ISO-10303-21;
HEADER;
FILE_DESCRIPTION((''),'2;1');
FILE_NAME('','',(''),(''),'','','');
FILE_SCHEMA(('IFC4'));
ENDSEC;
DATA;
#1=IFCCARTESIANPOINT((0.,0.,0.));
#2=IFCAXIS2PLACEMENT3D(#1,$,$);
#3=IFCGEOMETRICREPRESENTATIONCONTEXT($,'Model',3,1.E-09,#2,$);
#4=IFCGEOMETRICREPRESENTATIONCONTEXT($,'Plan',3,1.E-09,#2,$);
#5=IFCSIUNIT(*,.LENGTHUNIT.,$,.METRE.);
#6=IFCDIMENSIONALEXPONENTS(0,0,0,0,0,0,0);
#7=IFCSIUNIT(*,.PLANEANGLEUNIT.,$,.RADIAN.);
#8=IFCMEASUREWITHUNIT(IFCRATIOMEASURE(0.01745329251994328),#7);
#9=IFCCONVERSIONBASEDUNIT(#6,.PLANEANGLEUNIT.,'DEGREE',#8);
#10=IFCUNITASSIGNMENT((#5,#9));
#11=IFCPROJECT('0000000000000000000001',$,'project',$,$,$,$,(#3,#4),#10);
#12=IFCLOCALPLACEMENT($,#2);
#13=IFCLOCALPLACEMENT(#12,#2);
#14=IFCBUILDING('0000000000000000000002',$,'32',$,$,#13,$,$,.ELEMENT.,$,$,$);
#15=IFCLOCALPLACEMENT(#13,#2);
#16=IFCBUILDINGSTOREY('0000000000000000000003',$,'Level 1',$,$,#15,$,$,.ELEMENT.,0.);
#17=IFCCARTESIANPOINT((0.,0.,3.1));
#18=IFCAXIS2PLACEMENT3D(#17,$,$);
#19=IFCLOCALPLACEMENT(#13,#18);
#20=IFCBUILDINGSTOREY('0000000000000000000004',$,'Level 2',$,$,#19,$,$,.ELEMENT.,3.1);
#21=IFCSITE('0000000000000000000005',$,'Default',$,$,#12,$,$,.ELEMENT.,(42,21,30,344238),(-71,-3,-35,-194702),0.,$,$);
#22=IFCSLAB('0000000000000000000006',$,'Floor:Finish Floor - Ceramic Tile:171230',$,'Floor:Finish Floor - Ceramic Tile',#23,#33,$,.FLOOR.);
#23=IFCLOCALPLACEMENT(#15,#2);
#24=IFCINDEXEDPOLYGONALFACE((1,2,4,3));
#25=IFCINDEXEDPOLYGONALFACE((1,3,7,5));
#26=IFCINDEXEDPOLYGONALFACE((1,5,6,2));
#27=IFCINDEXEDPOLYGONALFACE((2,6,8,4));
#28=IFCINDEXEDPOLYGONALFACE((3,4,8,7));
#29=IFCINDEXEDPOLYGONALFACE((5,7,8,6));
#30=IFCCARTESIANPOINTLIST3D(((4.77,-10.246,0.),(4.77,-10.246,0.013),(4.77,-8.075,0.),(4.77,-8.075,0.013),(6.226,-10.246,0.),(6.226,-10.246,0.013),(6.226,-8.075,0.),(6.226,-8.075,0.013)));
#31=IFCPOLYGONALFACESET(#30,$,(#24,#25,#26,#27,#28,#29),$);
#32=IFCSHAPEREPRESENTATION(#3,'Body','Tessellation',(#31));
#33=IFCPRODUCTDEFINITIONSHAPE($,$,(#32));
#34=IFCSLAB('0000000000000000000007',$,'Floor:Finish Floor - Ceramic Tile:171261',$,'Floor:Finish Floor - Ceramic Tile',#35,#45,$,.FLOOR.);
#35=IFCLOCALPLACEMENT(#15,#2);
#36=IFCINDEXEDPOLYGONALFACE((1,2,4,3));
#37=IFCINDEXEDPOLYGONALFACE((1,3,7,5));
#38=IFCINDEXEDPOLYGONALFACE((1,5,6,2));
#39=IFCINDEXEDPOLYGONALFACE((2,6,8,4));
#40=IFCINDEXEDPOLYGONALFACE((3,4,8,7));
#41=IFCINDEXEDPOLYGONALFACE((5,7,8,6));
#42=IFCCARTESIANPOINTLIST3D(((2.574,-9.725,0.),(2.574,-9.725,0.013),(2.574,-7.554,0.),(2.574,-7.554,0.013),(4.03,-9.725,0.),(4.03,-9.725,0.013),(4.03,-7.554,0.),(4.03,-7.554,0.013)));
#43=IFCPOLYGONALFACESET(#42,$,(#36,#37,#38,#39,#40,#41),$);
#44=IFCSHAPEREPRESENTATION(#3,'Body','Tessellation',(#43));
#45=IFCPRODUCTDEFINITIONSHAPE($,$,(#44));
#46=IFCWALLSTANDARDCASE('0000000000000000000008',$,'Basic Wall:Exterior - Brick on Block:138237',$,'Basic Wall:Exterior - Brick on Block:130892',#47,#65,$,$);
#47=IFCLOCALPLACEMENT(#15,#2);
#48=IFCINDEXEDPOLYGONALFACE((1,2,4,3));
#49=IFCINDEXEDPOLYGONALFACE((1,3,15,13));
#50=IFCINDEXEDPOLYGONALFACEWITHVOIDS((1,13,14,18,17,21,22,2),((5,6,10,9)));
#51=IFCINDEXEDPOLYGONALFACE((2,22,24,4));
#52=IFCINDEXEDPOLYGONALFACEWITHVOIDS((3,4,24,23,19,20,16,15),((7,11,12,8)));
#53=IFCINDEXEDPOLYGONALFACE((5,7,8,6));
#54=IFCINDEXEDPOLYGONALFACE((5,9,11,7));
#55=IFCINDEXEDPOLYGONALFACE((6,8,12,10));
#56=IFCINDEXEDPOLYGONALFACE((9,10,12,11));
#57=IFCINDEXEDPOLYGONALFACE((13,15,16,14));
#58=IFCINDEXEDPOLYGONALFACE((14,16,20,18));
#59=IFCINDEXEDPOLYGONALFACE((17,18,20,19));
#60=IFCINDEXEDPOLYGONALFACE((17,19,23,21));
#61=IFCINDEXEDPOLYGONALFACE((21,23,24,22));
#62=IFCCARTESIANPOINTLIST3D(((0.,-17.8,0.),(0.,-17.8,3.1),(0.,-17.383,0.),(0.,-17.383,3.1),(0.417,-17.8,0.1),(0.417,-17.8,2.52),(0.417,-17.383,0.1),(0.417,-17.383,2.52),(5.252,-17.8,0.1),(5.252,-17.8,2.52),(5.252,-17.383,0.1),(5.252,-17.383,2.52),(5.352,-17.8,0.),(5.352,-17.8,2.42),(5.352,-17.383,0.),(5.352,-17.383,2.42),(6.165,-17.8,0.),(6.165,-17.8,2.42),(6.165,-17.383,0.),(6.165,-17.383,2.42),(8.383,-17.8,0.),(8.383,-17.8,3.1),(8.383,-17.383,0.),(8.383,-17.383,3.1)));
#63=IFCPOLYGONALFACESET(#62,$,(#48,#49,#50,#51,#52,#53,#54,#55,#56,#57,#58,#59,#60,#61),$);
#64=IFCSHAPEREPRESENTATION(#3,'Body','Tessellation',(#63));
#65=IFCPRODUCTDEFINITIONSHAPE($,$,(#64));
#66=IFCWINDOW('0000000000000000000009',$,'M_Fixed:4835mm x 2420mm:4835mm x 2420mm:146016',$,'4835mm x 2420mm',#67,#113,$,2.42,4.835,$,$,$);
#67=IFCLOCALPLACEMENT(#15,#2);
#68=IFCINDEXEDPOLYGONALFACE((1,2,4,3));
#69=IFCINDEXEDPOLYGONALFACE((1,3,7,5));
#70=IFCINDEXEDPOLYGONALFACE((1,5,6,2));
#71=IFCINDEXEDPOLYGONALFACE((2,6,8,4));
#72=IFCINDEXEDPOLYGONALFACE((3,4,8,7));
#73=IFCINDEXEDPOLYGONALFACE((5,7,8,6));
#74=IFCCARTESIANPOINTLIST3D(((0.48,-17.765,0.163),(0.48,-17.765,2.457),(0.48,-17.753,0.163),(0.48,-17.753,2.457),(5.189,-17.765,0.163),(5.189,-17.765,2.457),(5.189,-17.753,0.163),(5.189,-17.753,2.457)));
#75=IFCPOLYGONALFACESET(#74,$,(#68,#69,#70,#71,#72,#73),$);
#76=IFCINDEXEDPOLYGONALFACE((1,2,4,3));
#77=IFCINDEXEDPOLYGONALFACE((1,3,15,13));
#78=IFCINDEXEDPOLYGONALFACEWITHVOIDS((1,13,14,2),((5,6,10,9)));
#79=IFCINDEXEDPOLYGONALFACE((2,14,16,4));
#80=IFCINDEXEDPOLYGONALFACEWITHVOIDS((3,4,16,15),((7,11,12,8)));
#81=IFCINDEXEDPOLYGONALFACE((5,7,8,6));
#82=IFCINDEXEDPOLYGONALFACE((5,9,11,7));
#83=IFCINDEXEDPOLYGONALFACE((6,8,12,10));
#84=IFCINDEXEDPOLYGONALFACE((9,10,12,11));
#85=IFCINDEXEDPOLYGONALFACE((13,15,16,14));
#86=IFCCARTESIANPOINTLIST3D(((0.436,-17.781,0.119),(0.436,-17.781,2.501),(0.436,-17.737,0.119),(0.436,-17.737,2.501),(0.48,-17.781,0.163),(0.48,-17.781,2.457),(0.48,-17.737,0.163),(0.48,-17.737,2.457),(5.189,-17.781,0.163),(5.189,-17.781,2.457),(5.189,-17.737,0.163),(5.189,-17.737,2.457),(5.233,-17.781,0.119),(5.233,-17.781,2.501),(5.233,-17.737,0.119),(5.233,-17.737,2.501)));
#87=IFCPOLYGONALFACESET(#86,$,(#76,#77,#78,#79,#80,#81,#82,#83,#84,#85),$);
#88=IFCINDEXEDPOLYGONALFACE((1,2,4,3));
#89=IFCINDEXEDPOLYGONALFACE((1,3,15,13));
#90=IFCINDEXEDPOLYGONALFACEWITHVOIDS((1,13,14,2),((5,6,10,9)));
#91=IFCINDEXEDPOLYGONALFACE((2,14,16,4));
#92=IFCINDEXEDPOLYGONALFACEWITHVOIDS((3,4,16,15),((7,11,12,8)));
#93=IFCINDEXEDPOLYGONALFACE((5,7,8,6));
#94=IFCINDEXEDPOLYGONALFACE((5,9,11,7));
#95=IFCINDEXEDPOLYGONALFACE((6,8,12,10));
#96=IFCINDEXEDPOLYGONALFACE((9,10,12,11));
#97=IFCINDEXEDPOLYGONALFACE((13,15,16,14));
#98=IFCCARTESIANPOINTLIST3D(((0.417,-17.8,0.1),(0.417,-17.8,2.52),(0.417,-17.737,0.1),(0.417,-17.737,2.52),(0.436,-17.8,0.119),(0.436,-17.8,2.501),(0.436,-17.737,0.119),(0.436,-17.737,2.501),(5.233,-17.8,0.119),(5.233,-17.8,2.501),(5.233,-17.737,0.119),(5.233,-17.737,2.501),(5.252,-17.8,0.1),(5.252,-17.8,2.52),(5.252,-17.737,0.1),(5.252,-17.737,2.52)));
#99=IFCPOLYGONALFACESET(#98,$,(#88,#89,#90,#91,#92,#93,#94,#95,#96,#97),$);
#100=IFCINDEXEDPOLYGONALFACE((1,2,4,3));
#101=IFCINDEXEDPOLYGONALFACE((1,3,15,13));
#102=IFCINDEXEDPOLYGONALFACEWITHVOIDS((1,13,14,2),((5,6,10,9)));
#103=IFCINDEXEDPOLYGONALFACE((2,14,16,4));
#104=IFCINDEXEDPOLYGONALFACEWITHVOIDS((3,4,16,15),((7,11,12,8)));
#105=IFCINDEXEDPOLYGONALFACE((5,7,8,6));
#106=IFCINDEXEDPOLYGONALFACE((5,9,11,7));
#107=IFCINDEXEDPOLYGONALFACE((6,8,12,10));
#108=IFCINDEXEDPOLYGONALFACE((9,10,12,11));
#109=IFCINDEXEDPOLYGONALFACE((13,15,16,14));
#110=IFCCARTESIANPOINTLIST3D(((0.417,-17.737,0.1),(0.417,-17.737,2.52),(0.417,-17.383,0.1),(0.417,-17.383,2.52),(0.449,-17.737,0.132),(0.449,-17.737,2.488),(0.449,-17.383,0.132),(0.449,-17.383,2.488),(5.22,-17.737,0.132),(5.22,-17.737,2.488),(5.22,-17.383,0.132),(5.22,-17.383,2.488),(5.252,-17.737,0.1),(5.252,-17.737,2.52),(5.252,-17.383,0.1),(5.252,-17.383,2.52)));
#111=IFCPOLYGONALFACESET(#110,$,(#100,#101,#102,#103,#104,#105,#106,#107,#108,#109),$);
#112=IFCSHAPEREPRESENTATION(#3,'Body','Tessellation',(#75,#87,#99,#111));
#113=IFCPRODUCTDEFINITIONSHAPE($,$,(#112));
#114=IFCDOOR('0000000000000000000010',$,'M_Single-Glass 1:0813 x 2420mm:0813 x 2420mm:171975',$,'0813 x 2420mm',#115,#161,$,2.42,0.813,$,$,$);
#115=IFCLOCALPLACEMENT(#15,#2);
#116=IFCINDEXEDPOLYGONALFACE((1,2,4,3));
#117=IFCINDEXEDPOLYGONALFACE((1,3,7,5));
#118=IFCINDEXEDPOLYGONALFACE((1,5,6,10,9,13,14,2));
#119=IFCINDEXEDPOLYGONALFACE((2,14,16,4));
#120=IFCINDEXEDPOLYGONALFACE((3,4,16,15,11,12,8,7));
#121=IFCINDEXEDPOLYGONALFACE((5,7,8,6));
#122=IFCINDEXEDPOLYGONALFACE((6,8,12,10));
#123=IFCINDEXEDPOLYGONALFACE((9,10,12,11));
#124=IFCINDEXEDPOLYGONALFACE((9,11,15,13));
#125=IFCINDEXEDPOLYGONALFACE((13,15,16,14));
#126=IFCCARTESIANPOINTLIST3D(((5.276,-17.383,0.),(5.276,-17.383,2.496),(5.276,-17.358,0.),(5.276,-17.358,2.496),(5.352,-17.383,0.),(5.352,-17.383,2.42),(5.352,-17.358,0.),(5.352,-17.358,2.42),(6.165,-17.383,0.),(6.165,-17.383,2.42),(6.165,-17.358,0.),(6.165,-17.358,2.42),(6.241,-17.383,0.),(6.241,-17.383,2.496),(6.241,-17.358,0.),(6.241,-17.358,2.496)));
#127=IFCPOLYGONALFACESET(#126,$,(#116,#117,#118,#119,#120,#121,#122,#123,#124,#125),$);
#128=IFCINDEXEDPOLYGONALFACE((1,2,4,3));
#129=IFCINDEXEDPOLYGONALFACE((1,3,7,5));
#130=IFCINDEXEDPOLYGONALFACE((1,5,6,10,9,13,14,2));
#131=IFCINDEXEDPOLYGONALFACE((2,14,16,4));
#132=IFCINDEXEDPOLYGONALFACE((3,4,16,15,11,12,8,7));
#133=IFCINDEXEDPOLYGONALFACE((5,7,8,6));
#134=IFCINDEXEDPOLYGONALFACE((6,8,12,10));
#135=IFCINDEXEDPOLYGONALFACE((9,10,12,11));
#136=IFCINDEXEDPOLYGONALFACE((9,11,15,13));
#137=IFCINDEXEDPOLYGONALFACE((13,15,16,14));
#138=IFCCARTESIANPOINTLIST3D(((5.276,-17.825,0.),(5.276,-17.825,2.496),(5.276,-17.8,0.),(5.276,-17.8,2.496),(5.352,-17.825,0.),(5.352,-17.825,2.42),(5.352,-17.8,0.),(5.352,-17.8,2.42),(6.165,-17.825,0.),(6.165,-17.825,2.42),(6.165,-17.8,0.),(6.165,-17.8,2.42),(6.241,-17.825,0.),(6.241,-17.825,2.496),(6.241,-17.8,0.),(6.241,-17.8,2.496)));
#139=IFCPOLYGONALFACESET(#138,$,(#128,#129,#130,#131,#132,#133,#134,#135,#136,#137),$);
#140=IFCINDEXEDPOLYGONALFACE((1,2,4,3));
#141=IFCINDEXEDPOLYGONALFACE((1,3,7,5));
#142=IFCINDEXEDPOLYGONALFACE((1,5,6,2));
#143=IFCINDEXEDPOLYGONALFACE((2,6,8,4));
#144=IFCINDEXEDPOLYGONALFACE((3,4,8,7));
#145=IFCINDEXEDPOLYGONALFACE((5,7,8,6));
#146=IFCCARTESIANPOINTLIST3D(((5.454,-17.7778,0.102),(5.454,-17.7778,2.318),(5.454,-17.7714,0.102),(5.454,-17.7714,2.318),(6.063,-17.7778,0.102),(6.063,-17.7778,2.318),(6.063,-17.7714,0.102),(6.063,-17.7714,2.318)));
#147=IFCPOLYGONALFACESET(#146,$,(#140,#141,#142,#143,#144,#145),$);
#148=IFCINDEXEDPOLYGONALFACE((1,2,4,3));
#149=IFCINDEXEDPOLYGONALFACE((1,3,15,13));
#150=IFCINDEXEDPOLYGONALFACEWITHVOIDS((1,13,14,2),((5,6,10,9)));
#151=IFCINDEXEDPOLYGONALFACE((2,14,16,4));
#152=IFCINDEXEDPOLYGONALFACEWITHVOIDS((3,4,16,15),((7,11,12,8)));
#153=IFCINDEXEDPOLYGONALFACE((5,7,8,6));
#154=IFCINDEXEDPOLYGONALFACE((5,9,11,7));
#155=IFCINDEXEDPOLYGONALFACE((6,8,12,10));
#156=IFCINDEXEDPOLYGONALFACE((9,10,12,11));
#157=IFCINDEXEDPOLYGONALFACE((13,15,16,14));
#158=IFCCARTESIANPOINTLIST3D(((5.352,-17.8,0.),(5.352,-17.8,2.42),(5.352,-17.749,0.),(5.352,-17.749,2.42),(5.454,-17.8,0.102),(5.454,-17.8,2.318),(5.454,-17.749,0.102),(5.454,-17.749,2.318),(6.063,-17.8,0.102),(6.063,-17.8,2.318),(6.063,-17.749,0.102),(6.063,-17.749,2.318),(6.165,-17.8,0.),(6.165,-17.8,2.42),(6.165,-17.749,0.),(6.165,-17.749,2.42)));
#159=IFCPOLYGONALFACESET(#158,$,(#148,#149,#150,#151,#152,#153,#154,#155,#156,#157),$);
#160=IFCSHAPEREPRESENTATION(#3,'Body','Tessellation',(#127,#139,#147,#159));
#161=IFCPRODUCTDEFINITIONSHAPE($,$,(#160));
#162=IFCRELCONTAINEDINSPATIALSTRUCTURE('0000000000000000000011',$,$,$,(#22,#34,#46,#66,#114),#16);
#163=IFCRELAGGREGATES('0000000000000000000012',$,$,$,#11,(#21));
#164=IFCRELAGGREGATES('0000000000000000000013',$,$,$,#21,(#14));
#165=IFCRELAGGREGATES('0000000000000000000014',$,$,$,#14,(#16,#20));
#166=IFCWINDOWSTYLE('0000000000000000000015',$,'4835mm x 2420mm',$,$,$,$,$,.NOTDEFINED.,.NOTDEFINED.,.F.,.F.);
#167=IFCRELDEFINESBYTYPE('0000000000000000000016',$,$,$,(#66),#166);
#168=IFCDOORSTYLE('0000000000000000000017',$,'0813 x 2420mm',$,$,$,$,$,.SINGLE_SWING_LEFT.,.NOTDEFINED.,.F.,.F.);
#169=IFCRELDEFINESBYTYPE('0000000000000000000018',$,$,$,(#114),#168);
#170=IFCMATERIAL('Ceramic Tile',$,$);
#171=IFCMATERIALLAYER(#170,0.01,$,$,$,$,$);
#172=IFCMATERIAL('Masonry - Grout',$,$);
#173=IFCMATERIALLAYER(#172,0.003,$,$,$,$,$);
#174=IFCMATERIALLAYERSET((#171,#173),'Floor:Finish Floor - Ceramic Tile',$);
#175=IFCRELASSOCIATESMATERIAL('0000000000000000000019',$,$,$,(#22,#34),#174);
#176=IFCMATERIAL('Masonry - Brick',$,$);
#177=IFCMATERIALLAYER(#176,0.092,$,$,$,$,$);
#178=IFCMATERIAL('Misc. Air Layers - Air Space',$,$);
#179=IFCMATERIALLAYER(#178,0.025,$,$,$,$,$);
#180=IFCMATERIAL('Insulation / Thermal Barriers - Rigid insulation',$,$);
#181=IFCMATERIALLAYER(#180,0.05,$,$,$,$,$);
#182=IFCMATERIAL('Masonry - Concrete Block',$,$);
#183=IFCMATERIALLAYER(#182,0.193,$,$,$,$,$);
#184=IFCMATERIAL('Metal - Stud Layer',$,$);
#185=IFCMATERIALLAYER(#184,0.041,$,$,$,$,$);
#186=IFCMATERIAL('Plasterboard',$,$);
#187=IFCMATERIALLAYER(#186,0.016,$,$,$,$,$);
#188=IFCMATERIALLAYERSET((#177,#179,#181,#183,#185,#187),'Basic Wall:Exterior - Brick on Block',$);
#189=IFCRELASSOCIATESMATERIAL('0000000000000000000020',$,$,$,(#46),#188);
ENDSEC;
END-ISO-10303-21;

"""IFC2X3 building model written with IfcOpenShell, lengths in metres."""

from ifc_helpers import new_model, entity, si_unit, converted_unit, frame, frame_2d, origin, origin_2d_with_axis, place, context, project, spatial, polyline, rectangle, outline, extrude, source, transform, mapped, material, layer, layer_set, layer_usage, type_object, type_shapes, element, fill, save


model = new_model("IFC2X3")

# Units and contexts
model_context = context("Model", 3, precision=1e-09, world=origin())
plan_context = context("Plan", 3, precision=1e-09, world=origin())
ifc_project = project(units=[si_unit("LENGTHUNIT", "METRE"), converted_unit("PLANEANGLEUNIT", "DEGREE", entity("IfcRatioMeasure", 0.01745329251994328), si_unit("PLANEANGLEUNIT", "RADIAN"), dimensions=[0, 0, 0, 0, 0, 0, 0])], contexts=[model_context, plan_context])

# Site, building, storey
site_placement = place(None, origin())
site = spatial("IfcSite", under=ifc_project, at=site_placement, Name="Default", CompositionType="ELEMENT", RefLatitude=(42, 21, 30, 344238), RefLongitude=(-71, -3, -35, -194702), RefElevation=0.0)
building_placement = place(site_placement, origin())
building = spatial("IfcBuilding", under=site, at=building_placement, Name="32", CompositionType="ELEMENT")
storey_1_placement = place(building_placement, origin())
storey_1 = spatial("IfcBuildingStorey", under=building, at=storey_1_placement, Name="Level 1", CompositionType="ELEMENT", Elevation=0.0)

# Slabs
ifc_material_1 = material(Name="Ceramic Tile")
ifc_layer_1 = layer(ifc_material_1, 0.01)
ifc_material_2 = material(Name="Masonry - Grout")
ifc_layer_2 = layer(ifc_material_2, 0.003)
ifc_layer_set_1 = layer_set([ifc_layer_1, ifc_layer_2], Name="Floor:Finish Floor - Ceramic Tile")
ifc_layer_usage_1 = layer_usage(ifc_layer_set_1, "AXIS3", "POSITIVE", 0.0)
slab_1_placement = place(storey_1_placement, frame((4.77, -10.246, 0.0)))
element("IfcSlab", 1, at=slab_1_placement, inside=storey_1, material=ifc_layer_usage_1, Name="Floor:Finish Floor - Ceramic Tile:171230", ObjectType="Floor:Finish Floor - Ceramic Tile", PredefinedType="FLOOR", context=model_context, shape_type="SweptSolid", body=[
    extrude(rectangle(XDim=1.456, YDim=2.171, at=frame_2d((0.0, 0.0), x_axis=(-1.0, 0.0))), frame((0.728, 1.0855, 0.013), z_axis=(0.0, 0.0, -1.0), x_axis=(-1.0, 0.0, 0.0)), (0.0, 0.0, 1.0), 0.013),
])
ifc_layer_usage_2 = layer_usage(ifc_layer_set_1, "AXIS3", "POSITIVE", 0.0)
slab_2_placement = place(storey_1_placement, frame((2.574, -9.725, 0.0)))
element("IfcSlab", 2, at=slab_2_placement, inside=storey_1, material=ifc_layer_usage_2, Name="Floor:Finish Floor - Ceramic Tile:171261", ObjectType="Floor:Finish Floor - Ceramic Tile", PredefinedType="FLOOR", context=model_context, shape_type="SweptSolid", body=[
    extrude(rectangle(XDim=2.171, YDim=1.456, at=frame_2d((0.0, 0.0), x_axis=(0.0, -1.0))), frame((0.728, 1.0855, 0.013), z_axis=(0.0, 0.0, -1.0), x_axis=(-1.0, 0.0, 0.0)), (0.0, 0.0, 1.0), 0.013),
])

# Wall, openings, window, door
ifc_material_3 = material(Name="Masonry - Brick")
ifc_layer_3 = layer(ifc_material_3, 0.092)
ifc_material_4 = material(Name="Misc. Air Layers - Air Space")
ifc_layer_4 = layer(ifc_material_4, 0.025)
ifc_material_5 = material(Name="Insulation / Thermal Barriers - Rigid insulation")
ifc_layer_5 = layer(ifc_material_5, 0.05)
ifc_material_6 = material(Name="Masonry - Concrete Block")
ifc_layer_6 = layer(ifc_material_6, 0.193)
ifc_material_7 = material(Name="Metal - Stud Layer")
ifc_layer_7 = layer(ifc_material_7, 0.041)
ifc_material_8 = material(Name="Plasterboard")
ifc_layer_8 = layer(ifc_material_8, 0.016)
ifc_layer_set_2 = layer_set([ifc_layer_3, ifc_layer_4, ifc_layer_5, ifc_layer_6, ifc_layer_7, ifc_layer_8], Name="Basic Wall:Exterior - Brick on Block")
ifc_layer_usage_3 = layer_usage(ifc_layer_set_2, "AXIS2", "NEGATIVE", 0.2085)
wall_1_placement = place(storey_1_placement, frame((8.383, -17.5915, 0.0), z_axis=(0.0, 0.0, 1.0), x_axis=(-1.0, 0.0, 0.0)))
wall_1 = element("IfcWallStandardCase", 3, at=wall_1_placement, inside=storey_1, material=ifc_layer_usage_3, Name="Basic Wall:Exterior - Brick on Block:138237", ObjectType="Basic Wall:Exterior - Brick on Block:130892", context=model_context, shape_type="SweptSolid", body=[
    extrude(rectangle(XDim=8.383, YDim=0.417, at=frame_2d((4.1915, 0.0), x_axis=(-1.0, 0.0))), origin(), (0.0, 0.0, 1.0), 3.1),
])
opening_1_placement = place(wall_1_placement, frame((3.131, -0.2085, 0.1)))
opening_1 = element("IfcOpeningElement", 4, at=opening_1_placement, cuts=wall_1, ObjectType="Opening", context=model_context, shape_type="SweptSolid", body=[
    extrude(rectangle(XDim=2.42, YDim=4.835, at=frame_2d((1.21, 2.4175), x_axis=(1.0, 0.0))), frame((0.0, 0.0, 0.0), z_axis=(0.0, 1.0, 0.0), x_axis=(0.0, 0.0, 1.0)), (0.0, 0.0, 1.0), 0.417),
])
opening_2_placement = place(wall_1_placement, frame((2.218, -0.2085, 0.0)))
opening_2 = element("IfcOpeningElement", 5, at=opening_2_placement, cuts=wall_1, ObjectType="Opening", context=model_context, shape_type="SweptSolid", body=[
    extrude(rectangle(XDim=0.813, YDim=2.42, at=frame_2d((1.21, 0.4065), x_axis=(0.0, -1.0))), frame((0.0, 0.0, 0.0), z_axis=(0.0, 1.0, 0.0), x_axis=(0.0, 0.0, 1.0)), (0.0, 0.0, 1.0), 0.417),
])
window_style_1 = type_object("IfcWindowStyle", Name="4835mm x 2420mm", ConstructionType="NOTDEFINED", OperationType="NOTDEFINED", ParameterTakesPrecedence=False, Sizeable=False)
shared_shape_1 = source(origin(), model_context, "Body", "SweptSolid", [
    extrude(rectangle(XDim=0.012, YDim=4.709, at=origin_2d_with_axis()), frame((2.4175, 0.376, 0.063), z_axis=(0.0, 0.0, 1.0), x_axis=(0.0, -1.0, 0.0)), (0.0, 0.0, 1.0), 2.294),
    extrude(outline(polyline([(-2.3985, -1.191), (2.3985, -1.191), (2.3985, 1.191), (-2.3985, 1.191), (-2.3985, -1.191)]), holes=[polyline([(-2.3545, -1.147), (-2.3545, 1.147), (2.3545, 1.147), (2.3545, -1.147), (-2.3545, -1.147)])]), frame((2.4175, 0.354, 1.21), z_axis=(0.0, 1.0, 0.0), x_axis=(1.0, 0.0, 0.0)), (0.0, 0.0, 1.0), 0.044),
    extrude(outline(polyline([(-2.4175, -1.21), (2.4175, -1.21), (2.4175, 1.21), (-2.4175, 1.21), (-2.4175, -1.21)]), holes=[polyline([(-2.3985, -1.191), (-2.3985, 1.191), (2.3985, 1.191), (2.3985, -1.191), (-2.3985, -1.191)])]), frame((2.4175, 0.354, 1.21), z_axis=(0.0, 1.0, 0.0), x_axis=(1.0, 0.0, 0.0)), (0.0, 0.0, 1.0), 0.063),
    extrude(outline(polyline([(-2.4175, -1.21), (2.4175, -1.21), (2.4175, 1.21), (-2.4175, 1.21), (-2.4175, -1.21)]), holes=[polyline([(-2.3855, -1.178), (-2.3855, 1.178), (2.3855, 1.178), (2.3855, -1.178), (-2.3855, -1.178)])]), frame((2.4175, 0.0, 1.21), z_axis=(0.0, 1.0, 0.0), x_axis=(1.0, 0.0, 0.0)), (0.0, 0.0, 1.0), 0.354),
])
type_shapes(window_style_1, [shared_shape_1])
window_1_placement = place(opening_1_placement, origin())
window_1 = element("IfcWindow", 6, at=window_1_placement, inside=storey_1, type_object=window_style_1, Name="M_Fixed:4835mm x 2420mm:4835mm x 2420mm:146016", ObjectType="4835mm x 2420mm", OverallHeight=2.42, OverallWidth=4.835, context=model_context, shape_type="MappedRepresentation", body=[
    mapped(shared_shape_1, transform((0.0, 0.0, 0.0), scale=1.0)),
])
fill(opening_1, window_1)
door_style_1 = type_object("IfcDoorStyle", Name="0813 x 2420mm", ConstructionType="NOTDEFINED", OperationType="SINGLE_SWING_LEFT", ParameterTakesPrecedence=False, Sizeable=False)
shared_shape_2 = source(origin(), model_context, "Body", "SweptSolid", [
    extrude(outline(polyline([(-0.4065, -1.191), (-0.4065, 1.229), (-0.4825, 1.229), (-0.4825, -1.267), (0.4825, -1.267), (0.4825, 1.229), (0.4065, 1.229), (0.4065, -1.191), (-0.4065, -1.191)])), frame((0.4065, 0.0, 1.229), z_axis=(0.0, 1.0, 0.0), x_axis=(1.0, 0.0, 0.0)), (0.0, 0.0, -1.0), 0.025),
    extrude(outline(polyline([(-0.4065, -1.191), (-0.4065, 1.229), (-0.4825, 1.229), (-0.4825, -1.267), (0.4825, -1.267), (0.4825, 1.229), (0.4065, 1.229), (0.4065, -1.191), (-0.4065, -1.191)])), frame((0.4065, 0.442, 1.229), z_axis=(0.0, 1.0, 0.0), x_axis=(1.0, 0.0, 0.0)), (0.0, 0.0, -1.0), 0.025),
    extrude(rectangle(XDim=0.609, YDim=0.0064, at=origin_2d_with_axis()), frame((0.4065, 0.3916, 0.102)), (0.0, 0.0, 1.0), 2.216),
    extrude(outline(polyline([(-1.21, -0.4065), (1.21, -0.4065), (1.21, 0.4065), (-1.21, 0.4065), (-1.21, -0.4065)]), holes=[polyline([(-1.108, 0.3045), (1.108, 0.3045), (1.108, -0.3045), (-1.108, -0.3045), (-1.108, 0.3045)])]), frame((0.4065, 0.417, 1.21), z_axis=(0.0, -1.0, 0.0), x_axis=(0.0, 0.0, -1.0)), (0.0, 0.0, 1.0), 0.051),
])
type_shapes(door_style_1, [shared_shape_2])
door_1_placement = place(opening_2_placement, origin())
door_1 = element("IfcDoor", 7, at=door_1_placement, inside=storey_1, type_object=door_style_1, Name="M_Single-Glass 1:0813 x 2420mm:0813 x 2420mm:171975", ObjectType="0813 x 2420mm", OverallHeight=2.42, OverallWidth=0.813, context=model_context, shape_type="MappedRepresentation", body=[
    mapped(shared_shape_2, transform((0.0, 0.0, 0.0), scale=1.0)),
])
fill(opening_2, door_1)

# Shared definitions
storey_2_placement = place(building_placement, frame((0.0, 0.0, 3.1)))
storey_2 = spatial("IfcBuildingStorey", under=building, at=storey_2_placement, Name="Level 2", CompositionType="ELEMENT", Elevation=3.1)

save(model, "model.ifc")
